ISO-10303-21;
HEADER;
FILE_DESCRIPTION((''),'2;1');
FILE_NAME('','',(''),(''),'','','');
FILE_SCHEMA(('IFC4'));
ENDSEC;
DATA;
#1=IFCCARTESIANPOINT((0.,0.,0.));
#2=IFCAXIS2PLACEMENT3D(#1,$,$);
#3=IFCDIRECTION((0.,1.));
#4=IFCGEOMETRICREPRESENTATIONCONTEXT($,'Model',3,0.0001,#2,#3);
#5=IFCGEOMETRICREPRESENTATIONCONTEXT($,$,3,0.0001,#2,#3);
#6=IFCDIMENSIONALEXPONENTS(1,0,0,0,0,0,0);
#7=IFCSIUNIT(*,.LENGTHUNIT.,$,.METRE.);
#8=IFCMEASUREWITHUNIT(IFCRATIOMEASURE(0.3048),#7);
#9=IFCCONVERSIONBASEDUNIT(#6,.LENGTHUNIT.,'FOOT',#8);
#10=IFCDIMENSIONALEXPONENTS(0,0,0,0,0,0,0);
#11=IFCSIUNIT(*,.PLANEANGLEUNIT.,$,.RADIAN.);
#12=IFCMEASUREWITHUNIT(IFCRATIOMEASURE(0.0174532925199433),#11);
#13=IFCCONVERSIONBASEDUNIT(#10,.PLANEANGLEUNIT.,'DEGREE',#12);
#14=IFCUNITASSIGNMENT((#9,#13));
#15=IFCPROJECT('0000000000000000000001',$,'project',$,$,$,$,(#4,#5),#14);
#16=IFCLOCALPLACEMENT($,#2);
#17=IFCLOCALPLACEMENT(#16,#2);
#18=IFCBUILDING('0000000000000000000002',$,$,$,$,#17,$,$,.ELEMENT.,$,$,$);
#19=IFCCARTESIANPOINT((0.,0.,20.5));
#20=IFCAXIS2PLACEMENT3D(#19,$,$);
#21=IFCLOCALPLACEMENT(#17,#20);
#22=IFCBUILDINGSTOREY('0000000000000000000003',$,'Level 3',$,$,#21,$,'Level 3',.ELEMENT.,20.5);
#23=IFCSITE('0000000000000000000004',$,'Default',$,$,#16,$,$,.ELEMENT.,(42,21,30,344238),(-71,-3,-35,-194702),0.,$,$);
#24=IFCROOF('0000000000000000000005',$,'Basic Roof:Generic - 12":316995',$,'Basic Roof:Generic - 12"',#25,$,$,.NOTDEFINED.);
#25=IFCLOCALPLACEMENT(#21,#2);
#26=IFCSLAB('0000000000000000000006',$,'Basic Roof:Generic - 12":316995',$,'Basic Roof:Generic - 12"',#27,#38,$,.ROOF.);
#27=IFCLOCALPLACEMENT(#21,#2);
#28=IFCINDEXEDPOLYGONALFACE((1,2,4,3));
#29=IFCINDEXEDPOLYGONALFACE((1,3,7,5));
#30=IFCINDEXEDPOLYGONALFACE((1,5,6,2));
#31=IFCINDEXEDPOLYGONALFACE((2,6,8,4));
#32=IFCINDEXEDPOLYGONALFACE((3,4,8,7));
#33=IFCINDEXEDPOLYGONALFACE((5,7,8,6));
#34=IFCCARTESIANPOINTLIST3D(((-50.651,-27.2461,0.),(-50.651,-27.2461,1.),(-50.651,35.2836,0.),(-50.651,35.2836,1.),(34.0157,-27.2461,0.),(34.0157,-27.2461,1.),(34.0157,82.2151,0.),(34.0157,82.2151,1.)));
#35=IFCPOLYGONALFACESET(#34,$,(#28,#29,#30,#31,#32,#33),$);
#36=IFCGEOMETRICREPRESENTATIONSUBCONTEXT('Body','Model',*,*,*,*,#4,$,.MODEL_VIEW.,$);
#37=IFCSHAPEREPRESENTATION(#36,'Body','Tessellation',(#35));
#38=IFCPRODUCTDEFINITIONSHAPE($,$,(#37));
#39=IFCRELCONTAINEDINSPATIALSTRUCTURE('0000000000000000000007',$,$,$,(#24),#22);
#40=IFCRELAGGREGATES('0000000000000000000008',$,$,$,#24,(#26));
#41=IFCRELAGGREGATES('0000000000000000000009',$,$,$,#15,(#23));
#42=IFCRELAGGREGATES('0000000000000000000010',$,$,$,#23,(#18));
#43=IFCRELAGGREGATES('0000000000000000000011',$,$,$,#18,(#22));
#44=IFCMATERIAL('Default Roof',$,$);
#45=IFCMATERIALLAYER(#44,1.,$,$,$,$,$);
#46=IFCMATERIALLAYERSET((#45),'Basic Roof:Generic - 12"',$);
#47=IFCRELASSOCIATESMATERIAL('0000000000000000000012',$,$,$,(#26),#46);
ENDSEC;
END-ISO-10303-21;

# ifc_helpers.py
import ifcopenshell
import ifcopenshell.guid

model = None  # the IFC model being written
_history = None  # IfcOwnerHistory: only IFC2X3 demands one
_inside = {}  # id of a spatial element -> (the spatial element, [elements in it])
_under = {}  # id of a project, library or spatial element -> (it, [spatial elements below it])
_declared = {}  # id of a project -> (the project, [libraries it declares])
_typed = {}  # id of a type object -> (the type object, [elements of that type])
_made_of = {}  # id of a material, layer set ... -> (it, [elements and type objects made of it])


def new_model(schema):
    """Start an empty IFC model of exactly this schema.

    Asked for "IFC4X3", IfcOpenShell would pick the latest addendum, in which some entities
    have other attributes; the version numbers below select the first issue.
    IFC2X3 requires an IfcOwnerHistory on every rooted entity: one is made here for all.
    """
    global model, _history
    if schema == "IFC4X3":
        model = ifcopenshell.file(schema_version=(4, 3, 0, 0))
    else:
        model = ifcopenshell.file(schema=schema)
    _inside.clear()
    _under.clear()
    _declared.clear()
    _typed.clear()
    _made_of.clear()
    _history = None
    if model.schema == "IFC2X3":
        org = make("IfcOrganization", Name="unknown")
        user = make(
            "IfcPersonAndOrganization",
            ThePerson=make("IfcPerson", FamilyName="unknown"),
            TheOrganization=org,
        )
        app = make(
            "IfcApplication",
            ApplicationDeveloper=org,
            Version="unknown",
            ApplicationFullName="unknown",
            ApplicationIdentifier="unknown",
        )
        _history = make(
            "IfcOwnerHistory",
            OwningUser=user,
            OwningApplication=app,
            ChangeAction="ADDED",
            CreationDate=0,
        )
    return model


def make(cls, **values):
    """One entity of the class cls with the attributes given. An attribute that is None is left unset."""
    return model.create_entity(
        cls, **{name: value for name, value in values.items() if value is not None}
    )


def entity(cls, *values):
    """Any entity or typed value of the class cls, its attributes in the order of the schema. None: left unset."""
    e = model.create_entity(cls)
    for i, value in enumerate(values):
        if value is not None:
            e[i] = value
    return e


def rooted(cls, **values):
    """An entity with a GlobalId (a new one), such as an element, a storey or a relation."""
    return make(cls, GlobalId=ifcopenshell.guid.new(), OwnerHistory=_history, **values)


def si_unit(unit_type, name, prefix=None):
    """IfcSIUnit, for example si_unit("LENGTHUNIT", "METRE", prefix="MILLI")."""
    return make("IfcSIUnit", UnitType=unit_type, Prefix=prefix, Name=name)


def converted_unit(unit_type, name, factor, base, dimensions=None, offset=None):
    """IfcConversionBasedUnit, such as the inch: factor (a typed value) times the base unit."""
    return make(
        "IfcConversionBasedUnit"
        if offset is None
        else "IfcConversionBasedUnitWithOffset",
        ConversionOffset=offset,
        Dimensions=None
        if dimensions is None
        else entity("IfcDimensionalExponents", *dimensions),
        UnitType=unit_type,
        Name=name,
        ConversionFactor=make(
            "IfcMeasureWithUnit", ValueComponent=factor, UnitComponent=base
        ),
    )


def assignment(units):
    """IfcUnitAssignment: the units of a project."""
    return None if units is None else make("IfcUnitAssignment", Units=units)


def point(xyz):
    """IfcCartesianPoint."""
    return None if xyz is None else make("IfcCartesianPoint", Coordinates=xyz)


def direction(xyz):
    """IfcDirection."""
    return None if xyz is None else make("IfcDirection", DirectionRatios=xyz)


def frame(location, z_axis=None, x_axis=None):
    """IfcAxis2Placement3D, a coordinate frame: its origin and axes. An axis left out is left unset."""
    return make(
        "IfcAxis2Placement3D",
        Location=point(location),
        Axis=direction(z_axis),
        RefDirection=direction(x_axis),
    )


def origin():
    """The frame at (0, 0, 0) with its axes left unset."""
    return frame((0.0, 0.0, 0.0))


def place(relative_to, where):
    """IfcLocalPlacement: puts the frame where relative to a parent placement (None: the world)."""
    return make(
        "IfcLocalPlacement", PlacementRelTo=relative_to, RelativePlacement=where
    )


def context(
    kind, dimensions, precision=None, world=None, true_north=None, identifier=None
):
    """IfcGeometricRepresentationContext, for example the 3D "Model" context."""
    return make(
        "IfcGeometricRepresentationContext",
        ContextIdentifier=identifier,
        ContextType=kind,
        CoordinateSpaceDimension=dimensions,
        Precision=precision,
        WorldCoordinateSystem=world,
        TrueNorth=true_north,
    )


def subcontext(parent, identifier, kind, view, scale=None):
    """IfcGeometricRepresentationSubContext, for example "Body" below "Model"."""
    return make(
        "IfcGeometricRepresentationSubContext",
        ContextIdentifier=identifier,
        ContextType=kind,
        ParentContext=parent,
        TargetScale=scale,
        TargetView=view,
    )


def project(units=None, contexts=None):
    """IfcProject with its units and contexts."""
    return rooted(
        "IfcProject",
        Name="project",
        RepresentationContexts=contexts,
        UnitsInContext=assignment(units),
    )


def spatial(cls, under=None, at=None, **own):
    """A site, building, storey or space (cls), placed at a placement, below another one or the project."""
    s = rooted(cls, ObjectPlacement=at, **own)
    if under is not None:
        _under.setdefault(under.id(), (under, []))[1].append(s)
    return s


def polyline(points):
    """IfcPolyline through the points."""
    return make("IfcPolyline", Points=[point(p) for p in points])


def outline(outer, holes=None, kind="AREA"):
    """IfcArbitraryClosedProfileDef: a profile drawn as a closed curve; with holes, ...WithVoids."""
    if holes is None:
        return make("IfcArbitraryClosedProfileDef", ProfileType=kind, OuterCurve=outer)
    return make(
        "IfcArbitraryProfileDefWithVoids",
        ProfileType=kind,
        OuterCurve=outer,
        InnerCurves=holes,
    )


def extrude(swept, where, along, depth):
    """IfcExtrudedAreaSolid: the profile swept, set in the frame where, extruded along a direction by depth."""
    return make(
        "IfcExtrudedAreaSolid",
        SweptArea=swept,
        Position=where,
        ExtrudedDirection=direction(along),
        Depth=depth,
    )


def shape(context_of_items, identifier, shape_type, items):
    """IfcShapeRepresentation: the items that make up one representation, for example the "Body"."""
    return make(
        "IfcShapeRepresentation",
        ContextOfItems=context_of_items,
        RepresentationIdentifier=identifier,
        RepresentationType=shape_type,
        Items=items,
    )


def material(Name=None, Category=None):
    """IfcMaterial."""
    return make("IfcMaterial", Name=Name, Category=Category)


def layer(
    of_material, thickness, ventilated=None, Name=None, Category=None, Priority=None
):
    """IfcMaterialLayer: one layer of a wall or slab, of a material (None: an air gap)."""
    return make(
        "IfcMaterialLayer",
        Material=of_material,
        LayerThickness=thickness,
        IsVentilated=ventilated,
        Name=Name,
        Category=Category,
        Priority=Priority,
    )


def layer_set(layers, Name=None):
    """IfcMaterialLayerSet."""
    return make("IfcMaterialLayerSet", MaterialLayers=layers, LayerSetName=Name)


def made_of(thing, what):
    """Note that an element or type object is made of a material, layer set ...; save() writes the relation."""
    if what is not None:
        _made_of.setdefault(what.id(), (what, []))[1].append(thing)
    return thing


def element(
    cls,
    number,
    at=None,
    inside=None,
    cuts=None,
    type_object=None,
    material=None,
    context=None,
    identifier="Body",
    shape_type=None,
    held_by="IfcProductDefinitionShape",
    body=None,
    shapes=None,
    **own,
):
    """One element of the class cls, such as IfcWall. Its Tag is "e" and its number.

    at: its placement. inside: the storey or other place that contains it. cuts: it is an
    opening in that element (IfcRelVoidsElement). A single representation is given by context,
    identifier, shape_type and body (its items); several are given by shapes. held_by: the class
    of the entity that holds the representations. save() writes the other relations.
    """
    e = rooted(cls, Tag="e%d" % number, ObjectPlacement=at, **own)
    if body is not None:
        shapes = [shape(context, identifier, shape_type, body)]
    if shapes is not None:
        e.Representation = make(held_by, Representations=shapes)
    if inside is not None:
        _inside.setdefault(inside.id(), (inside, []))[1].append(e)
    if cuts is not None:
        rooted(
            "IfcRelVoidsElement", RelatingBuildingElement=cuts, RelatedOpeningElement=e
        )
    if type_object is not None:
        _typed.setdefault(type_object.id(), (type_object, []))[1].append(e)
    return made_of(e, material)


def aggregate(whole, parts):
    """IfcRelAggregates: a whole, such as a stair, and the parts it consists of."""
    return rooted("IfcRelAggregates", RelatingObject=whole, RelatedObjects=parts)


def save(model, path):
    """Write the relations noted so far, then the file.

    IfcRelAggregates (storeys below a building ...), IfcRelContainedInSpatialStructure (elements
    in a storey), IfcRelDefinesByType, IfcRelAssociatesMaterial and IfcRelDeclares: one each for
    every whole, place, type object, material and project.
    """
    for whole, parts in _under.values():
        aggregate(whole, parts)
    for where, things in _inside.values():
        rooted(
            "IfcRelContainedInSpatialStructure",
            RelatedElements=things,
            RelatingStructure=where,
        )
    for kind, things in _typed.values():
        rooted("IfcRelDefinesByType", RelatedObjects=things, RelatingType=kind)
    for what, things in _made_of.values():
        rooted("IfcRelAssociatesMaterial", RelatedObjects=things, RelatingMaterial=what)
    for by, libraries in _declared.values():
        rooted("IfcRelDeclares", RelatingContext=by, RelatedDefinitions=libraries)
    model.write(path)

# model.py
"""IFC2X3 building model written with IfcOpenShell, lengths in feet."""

from ifc_helpers import new_model, entity, si_unit, converted_unit, direction, frame, origin, place, context, subcontext, project, spatial, polyline, outline, extrude, material, layer, layer_set, element, aggregate, save


model = new_model("IFC2X3")

# Units and contexts
model_context = context("Model", 3, precision=0.0001, world=origin(), true_north=direction((0.0, 1.0)))
context_of_model = context(None, 3, precision=0.0001, world=origin(), true_north=direction((0.0, 1.0)))
body_context = subcontext(model_context, "Body", "Model", "MODEL_VIEW")
ifc_project = project(units=[converted_unit("LENGTHUNIT", "FOOT", entity("IfcRatioMeasure", 0.3048), si_unit("LENGTHUNIT", "METRE"), dimensions=[1, 0, 0, 0, 0, 0, 0]), converted_unit("PLANEANGLEUNIT", "DEGREE", entity("IfcRatioMeasure", 0.0174532925199433), si_unit("PLANEANGLEUNIT", "RADIAN"), dimensions=[0, 0, 0, 0, 0, 0, 0])], contexts=[model_context, context_of_model])

# Site, building, storey
site_placement = place(None, origin())
site = spatial("IfcSite", under=ifc_project, at=site_placement, Name="Default", CompositionType="ELEMENT", RefLatitude=(42, 21, 30, 344238), RefLongitude=(-71, -3, -35, -194702), RefElevation=0.0)
building_placement = place(site_placement, origin())
building = spatial("IfcBuilding", under=site, at=building_placement, CompositionType="ELEMENT")
storey_placement = place(building_placement, frame((0.0, 0.0, 20.5)))
storey = spatial("IfcBuildingStorey", under=building, at=storey_placement, Name="Level 3", LongName="Level 3", CompositionType="ELEMENT", Elevation=20.5)

# Roof, slab
roof_placement = place(storey_placement, frame((-50.651, -27.2461, 0.0)))
roof = element("IfcRoof", 1, at=roof_placement, inside=storey, Name="Basic Roof:Generic - 12\":316995", ObjectType="Basic Roof:Generic - 12\"", ShapeType="NOTDEFINED")
ifc_material = material(Name="Default Roof")
ifc_layer = layer(ifc_material, 1.0)
ifc_layer_set = layer_set([ifc_layer], Name="Basic Roof:Generic - 12\"")
slab_placement = place(roof_placement, origin())
slab = element("IfcSlab", 2, at=slab_placement, material=ifc_layer_set, Name="Basic Roof:Generic - 12\":316995", ObjectType="Basic Roof:Generic - 12\"", PredefinedType="ROOF", context=body_context, shape_type="SweptSolid", body=[
    extrude(outline(polyline([(-42.3333, -54.7306), (42.3333, -54.7306), (42.3333, 54.7306), (-42.3333, 7.7991), (-42.3333, -54.7306)])), frame((42.3333, 54.7306, 0.0)), (0.0, 0.0, 1.0), 1.0),
])
aggregate(roof, [slab])

save(model, "model.ifc")
